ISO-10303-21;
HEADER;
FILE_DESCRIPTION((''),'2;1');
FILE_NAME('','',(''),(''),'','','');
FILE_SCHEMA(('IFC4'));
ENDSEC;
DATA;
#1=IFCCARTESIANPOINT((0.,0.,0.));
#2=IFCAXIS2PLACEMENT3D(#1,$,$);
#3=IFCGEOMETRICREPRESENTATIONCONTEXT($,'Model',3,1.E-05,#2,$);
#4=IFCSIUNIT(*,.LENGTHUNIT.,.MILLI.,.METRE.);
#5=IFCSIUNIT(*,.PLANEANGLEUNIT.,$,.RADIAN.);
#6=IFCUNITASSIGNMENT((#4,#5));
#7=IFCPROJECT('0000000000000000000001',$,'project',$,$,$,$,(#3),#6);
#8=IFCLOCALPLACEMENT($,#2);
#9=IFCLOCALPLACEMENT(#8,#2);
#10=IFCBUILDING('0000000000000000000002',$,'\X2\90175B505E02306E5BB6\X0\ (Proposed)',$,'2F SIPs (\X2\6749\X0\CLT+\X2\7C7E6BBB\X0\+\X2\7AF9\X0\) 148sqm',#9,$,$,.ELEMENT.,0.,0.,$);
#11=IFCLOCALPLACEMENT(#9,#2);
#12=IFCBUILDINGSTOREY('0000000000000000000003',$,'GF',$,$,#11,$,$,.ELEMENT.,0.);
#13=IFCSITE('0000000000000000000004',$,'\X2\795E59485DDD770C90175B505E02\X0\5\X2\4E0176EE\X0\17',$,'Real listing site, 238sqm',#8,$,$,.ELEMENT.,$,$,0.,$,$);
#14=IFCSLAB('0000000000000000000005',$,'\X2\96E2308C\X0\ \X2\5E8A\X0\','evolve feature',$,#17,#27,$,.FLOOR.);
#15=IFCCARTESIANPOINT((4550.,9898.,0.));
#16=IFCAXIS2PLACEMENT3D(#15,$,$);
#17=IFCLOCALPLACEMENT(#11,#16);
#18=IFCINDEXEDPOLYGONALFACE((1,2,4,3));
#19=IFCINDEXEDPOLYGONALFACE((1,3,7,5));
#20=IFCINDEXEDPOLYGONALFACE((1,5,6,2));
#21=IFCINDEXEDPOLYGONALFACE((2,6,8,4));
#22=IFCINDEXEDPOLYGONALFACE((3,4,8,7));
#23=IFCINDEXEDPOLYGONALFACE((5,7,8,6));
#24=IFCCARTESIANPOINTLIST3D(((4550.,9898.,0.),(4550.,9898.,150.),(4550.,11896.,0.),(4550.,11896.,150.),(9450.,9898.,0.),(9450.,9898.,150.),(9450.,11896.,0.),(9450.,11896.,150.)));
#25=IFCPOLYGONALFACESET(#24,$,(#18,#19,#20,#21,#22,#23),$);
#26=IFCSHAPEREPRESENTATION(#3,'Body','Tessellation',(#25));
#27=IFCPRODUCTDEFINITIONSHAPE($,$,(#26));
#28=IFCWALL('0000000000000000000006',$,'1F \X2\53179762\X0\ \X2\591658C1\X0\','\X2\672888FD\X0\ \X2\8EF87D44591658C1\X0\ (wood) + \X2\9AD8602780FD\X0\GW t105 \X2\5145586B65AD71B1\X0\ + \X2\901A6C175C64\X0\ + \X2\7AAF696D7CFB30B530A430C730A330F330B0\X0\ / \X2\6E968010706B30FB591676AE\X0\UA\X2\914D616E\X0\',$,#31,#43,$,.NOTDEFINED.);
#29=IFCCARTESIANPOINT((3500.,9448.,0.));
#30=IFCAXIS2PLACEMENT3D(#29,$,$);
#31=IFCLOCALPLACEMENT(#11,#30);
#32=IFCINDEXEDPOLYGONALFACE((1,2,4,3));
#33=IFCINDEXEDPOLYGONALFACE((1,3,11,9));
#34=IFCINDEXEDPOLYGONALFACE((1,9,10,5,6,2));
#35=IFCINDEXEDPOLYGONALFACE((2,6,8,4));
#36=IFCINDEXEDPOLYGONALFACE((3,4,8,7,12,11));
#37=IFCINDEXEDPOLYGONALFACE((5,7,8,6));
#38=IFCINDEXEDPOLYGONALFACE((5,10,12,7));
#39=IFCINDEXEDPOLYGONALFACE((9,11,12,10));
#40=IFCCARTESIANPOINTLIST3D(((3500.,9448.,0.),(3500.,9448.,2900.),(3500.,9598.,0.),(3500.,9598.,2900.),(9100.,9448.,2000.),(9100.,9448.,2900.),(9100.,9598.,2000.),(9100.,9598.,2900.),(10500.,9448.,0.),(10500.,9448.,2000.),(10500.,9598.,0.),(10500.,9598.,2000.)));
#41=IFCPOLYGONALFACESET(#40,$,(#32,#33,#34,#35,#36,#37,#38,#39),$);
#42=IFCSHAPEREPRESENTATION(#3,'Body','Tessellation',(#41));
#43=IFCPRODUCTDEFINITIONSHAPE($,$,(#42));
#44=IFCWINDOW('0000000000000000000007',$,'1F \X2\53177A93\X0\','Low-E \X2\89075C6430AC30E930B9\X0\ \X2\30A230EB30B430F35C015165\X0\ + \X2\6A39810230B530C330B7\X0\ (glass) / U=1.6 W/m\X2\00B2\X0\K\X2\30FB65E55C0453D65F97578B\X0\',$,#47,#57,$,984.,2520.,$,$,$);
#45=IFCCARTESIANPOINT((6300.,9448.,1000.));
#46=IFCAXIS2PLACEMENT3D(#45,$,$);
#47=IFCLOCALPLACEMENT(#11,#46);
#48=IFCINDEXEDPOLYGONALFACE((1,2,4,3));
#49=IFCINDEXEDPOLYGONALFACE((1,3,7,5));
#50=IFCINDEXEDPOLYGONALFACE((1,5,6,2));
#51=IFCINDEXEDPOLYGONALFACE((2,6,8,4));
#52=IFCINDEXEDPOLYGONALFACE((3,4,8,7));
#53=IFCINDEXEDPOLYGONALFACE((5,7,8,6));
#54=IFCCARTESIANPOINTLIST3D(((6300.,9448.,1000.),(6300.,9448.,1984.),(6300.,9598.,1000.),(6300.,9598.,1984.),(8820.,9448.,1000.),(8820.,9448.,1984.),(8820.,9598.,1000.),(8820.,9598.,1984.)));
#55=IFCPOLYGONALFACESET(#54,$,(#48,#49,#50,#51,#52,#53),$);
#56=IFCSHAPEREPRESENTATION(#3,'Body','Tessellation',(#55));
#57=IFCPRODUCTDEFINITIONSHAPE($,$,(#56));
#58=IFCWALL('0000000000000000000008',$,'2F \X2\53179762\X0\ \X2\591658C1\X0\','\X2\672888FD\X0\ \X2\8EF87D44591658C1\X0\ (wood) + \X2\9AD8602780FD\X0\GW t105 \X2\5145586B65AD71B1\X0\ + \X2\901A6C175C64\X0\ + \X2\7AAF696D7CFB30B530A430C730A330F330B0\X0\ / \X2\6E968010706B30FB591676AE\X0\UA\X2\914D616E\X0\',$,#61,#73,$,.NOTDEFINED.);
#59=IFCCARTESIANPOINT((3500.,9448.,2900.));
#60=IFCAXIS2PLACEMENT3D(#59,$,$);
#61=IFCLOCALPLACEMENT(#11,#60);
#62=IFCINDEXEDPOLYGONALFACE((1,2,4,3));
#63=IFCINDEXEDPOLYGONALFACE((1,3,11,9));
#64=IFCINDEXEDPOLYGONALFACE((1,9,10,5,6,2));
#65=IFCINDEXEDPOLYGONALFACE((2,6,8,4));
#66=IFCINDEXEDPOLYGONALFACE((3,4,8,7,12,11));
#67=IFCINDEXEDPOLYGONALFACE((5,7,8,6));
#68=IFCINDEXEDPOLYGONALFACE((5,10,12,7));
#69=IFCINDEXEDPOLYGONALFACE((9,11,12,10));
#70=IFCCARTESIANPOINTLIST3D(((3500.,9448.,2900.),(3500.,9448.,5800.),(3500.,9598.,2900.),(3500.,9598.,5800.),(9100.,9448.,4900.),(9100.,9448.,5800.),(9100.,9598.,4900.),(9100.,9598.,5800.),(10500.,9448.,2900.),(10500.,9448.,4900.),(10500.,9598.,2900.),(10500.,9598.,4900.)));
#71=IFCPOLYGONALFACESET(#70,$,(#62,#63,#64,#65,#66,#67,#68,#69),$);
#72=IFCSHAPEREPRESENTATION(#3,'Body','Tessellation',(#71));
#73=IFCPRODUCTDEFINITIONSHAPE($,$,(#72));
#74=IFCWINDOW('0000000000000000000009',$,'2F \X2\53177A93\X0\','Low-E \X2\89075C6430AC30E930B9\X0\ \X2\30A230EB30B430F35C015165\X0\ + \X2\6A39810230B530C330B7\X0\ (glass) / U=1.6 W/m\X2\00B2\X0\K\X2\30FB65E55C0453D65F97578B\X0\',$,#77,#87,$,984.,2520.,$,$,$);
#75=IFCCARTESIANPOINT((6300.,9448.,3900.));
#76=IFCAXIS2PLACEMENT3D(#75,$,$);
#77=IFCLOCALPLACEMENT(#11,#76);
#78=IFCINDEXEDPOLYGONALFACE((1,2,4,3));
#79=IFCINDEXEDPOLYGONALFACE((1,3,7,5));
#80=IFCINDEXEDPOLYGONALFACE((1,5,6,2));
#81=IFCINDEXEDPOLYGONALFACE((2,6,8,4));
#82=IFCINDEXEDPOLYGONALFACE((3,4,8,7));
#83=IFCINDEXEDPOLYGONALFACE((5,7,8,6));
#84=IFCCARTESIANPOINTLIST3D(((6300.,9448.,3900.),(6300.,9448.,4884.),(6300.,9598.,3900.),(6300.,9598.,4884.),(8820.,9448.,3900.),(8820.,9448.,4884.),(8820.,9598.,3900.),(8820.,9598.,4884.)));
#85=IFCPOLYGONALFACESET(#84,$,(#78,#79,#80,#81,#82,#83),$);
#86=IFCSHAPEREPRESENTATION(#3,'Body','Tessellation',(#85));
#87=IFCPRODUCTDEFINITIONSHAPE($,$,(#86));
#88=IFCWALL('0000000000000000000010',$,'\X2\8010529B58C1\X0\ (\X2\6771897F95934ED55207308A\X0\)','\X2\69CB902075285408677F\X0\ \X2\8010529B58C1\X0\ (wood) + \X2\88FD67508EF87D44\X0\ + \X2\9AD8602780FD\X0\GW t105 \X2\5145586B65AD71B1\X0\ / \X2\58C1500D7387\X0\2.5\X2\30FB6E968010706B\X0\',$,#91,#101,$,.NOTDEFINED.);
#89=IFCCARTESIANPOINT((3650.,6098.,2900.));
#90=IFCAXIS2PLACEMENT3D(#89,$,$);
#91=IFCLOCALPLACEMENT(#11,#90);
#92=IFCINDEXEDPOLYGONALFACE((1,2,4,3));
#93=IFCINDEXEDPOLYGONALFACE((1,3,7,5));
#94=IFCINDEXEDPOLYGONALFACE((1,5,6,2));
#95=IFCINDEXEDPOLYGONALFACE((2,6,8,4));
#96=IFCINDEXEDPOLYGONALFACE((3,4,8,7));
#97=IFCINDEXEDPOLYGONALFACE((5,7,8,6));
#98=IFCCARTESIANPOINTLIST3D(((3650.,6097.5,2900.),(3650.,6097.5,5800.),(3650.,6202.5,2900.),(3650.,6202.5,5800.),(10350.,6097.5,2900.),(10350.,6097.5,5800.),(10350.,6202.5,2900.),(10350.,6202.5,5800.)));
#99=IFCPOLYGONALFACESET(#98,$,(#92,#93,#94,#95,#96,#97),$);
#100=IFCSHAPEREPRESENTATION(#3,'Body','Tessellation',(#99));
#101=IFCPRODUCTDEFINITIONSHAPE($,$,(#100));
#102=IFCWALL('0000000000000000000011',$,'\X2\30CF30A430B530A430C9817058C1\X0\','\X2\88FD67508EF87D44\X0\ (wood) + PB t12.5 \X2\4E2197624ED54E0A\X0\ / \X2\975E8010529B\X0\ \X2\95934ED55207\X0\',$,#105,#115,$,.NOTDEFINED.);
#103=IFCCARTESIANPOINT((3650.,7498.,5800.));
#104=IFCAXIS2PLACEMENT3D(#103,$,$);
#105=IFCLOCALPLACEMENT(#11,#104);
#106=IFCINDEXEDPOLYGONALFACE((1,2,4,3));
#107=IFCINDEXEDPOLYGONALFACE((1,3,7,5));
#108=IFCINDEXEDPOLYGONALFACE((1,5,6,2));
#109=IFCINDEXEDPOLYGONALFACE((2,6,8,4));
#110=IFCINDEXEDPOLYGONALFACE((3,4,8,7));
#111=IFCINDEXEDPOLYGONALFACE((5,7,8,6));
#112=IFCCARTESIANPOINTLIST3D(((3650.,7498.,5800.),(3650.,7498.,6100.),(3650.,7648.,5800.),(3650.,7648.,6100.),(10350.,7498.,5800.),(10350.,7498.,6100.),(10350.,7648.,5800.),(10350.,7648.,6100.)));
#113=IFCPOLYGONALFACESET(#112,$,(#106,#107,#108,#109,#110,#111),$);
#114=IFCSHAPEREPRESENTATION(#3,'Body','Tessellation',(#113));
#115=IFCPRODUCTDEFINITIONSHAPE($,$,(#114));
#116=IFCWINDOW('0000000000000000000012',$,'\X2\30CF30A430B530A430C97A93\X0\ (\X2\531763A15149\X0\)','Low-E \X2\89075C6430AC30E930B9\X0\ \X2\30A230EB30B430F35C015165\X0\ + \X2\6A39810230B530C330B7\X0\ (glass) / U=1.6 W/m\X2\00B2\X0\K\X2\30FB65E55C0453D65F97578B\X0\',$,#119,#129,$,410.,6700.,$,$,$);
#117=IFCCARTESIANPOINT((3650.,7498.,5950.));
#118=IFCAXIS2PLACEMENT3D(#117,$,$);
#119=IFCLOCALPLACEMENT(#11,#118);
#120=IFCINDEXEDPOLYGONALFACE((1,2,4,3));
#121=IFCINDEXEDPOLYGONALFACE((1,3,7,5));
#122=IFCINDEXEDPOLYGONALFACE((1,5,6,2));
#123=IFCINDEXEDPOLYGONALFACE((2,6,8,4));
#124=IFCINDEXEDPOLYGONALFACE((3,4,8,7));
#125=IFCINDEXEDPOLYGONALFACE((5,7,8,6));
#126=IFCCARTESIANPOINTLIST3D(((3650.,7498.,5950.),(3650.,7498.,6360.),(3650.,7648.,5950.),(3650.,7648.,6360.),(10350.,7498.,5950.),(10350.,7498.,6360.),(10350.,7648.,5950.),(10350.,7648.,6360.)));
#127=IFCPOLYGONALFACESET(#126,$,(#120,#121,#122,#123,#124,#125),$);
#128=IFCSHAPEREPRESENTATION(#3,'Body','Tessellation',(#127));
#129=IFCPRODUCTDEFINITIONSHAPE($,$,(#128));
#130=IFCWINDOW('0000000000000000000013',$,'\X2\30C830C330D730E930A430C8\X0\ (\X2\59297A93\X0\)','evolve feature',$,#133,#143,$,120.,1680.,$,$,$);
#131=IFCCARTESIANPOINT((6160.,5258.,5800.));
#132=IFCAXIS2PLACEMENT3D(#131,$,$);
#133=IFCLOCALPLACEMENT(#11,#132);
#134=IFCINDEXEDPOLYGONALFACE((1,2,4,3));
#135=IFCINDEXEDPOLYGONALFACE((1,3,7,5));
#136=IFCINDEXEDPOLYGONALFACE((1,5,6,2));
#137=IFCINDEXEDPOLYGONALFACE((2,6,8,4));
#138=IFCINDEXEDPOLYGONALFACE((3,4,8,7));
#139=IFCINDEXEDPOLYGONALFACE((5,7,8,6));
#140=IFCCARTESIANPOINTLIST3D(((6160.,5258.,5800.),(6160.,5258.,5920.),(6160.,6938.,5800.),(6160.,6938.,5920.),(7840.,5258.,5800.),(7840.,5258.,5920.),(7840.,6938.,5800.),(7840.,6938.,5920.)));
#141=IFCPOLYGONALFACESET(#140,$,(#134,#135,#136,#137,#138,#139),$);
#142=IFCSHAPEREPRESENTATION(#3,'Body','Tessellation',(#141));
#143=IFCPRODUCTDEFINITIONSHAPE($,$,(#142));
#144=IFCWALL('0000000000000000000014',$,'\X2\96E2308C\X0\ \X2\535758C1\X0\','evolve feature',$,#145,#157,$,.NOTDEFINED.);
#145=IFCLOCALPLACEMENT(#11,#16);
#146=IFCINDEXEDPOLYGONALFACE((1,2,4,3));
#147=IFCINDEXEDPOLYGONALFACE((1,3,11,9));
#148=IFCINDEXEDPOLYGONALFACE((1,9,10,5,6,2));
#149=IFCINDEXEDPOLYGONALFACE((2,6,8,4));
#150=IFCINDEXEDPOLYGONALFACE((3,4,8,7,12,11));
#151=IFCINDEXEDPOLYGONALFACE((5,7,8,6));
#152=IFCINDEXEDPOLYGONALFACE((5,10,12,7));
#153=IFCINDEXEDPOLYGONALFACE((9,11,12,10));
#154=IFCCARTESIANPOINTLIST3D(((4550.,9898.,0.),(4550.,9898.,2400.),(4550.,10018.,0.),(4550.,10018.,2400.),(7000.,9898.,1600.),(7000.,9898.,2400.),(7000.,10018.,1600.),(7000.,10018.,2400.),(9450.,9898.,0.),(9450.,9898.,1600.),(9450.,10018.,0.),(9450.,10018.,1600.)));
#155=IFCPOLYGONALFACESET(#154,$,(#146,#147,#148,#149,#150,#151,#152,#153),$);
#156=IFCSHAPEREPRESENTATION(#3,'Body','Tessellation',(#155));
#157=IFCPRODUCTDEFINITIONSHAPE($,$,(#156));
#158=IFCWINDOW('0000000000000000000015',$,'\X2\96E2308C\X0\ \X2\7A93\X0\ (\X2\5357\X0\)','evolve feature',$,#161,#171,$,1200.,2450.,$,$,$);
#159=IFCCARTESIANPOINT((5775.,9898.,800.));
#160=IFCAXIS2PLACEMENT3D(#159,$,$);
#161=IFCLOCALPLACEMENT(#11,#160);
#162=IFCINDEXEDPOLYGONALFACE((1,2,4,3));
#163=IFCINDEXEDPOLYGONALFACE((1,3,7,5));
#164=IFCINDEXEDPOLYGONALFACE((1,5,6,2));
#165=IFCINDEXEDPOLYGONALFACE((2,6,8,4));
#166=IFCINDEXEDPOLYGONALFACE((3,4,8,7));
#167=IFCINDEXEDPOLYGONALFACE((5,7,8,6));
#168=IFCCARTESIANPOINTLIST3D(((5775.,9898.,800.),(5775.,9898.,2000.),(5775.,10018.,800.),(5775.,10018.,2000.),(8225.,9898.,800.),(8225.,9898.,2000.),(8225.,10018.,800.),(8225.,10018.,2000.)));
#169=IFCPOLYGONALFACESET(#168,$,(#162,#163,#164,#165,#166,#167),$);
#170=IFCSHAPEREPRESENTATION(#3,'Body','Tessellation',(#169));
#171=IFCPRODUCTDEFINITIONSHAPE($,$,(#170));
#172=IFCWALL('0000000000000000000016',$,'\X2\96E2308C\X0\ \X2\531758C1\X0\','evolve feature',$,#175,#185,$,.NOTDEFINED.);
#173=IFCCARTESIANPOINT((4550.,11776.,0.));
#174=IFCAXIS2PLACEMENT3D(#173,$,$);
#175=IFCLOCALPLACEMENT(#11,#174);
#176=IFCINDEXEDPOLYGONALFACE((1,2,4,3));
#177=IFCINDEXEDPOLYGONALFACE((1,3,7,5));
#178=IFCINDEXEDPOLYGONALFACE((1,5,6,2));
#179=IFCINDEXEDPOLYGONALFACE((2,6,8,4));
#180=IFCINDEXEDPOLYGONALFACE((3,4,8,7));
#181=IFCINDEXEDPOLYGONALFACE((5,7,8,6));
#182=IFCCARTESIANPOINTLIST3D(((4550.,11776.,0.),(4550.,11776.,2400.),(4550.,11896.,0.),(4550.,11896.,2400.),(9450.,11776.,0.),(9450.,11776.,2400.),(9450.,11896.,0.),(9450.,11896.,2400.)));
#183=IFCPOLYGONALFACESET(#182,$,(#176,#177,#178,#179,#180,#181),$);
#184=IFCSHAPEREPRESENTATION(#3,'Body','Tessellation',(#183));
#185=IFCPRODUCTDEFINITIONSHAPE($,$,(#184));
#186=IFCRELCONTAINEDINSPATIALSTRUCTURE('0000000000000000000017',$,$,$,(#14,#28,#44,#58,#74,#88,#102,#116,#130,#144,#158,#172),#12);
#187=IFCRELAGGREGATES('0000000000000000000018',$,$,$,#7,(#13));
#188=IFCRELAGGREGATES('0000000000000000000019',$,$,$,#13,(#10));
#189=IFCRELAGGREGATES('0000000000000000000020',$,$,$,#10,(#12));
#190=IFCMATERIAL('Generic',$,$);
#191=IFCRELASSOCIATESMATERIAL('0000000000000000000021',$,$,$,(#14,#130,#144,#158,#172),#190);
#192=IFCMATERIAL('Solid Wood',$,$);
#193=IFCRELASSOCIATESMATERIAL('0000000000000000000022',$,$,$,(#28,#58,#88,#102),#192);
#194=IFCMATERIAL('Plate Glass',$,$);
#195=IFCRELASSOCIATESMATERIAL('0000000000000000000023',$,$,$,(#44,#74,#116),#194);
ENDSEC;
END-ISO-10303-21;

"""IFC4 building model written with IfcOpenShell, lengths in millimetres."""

from ifc_helpers import new_model, si_unit, frame, frame_2d, origin, place, context, project, spatial, rectangle, extrude, material, element, fill, save


model = new_model("IFC4")

# Units and contexts
model_context = context("Model", 3, precision=1e-05, world=origin())
ifc_project = project(units=[si_unit("LENGTHUNIT", "METRE", prefix="MILLI"), si_unit("PLANEANGLEUNIT", "RADIAN")], contexts=[model_context])

# Site, building, storey
site_placement = place(None, origin())
site = spatial("IfcSite", under=ifc_project, at=site_placement, Name="神奈川県逗子市5丁目17", ObjectType="Real listing site, 238sqm", CompositionType="ELEMENT", RefElevation=0.0)
building_placement = place(site_placement, origin())
building = spatial("IfcBuilding", under=site, at=building_placement, Name="逗子市の家 (Proposed)", ObjectType="2F SIPs (杉CLT+籾殻+竹) 148sqm", CompositionType="ELEMENT", ElevationOfRefHeight=0.0, ElevationOfTerrain=0.0)
storey_placement = place(building_placement, origin())
storey = spatial("IfcBuildingStorey", under=building, at=storey_placement, Name="GF", CompositionType="ELEMENT", Elevation=0.0)

# Slab
ifc_material_1 = material(Name="Generic")
slab_placement = place(storey_placement, frame((4550.0, 9898.0, 0.0)))
element("IfcSlab", 1, at=slab_placement, inside=storey, material=ifc_material_1, Name="離れ 床", Description="evolve feature", PredefinedType="FLOOR", context=model_context, shape_type="SweptSolid", body=[
    extrude(rectangle(XDim=4900.0, YDim=1998.0, at=frame_2d((2450.0, 999.0))), frame((4550.0, 9898.0, 0.0)), (0.0, 0.0, 1.0), 150.0),
])

# Wall, opening, window
ifc_material_2 = material(Name="Solid Wood")
wall_1_placement = place(storey_placement, frame((3500.0, 9448.0, 0.0)))
wall_1 = element("IfcWall", 2, at=wall_1_placement, inside=storey, material=ifc_material_2, Name="1F 北面 外壁", Description="木製 軸組外壁 (wood) + 高性能GW t105 充填断熱 + 通気層 + 窯業系サイディング / 準耐火・外皮UA配慮", PredefinedType="NOTDEFINED", context=model_context, shape_type="SweptSolid", body=[
    extrude(rectangle(XDim=7000.0, YDim=150.0, at=frame_2d((3500.0, 75.0))), frame((3500.0, 9448.0, 0.0)), (0.0, 0.0, 1.0), 2900.0),
])
opening_1_placement = place(storey_placement, frame((6300.0, 9448.0, 1000.0)))
opening_1 = element("IfcOpeningElement", 3, at=opening_1_placement, cuts=wall_1, PredefinedType="NOTDEFINED", context=model_context, shape_type="SweptSolid", body=[
    extrude(rectangle(XDim=2520.0, YDim=150.0, at=frame_2d((1260.0, 75.0))), frame((6300.0, 9448.0, 1000.0)), (0.0, 0.0, 1.0), 984.0),
])
ifc_material_3 = material(Name="Plate Glass")
window_1_placement = place(storey_placement, frame((6300.0, 9448.0, 1000.0)))
window_1 = element("IfcWindow", 4, at=window_1_placement, inside=storey, material=ifc_material_3, Name="1F 北窓", Description="Low-E 複層ガラス アルゴン封入 + 樹脂サッシ (glass) / U=1.6 W/m²K・日射取得型", OverallHeight=984.0, OverallWidth=2520.0, context=model_context, shape_type="SweptSolid", body=[
    extrude(rectangle(XDim=2520.0, YDim=150.0, at=frame_2d((1260.0, 75.0))), frame((6300.0, 9448.0, 1000.0)), (0.0, 0.0, 1.0), 984.0),
])
fill(opening_1, window_1)

# Wall, opening, window
wall_2_placement = place(storey_placement, frame((3500.0, 9448.0, 2900.0)))
wall_2 = element("IfcWall", 5, at=wall_2_placement, inside=storey, material=ifc_material_2, Name="2F 北面 外壁", Description="木製 軸組外壁 (wood) + 高性能GW t105 充填断熱 + 通気層 + 窯業系サイディング / 準耐火・外皮UA配慮", PredefinedType="NOTDEFINED", context=model_context, shape_type="SweptSolid", body=[
    extrude(rectangle(XDim=7000.0, YDim=150.0, at=frame_2d((3500.0, 75.0))), frame((3500.0, 9448.0, 2900.0)), (0.0, 0.0, 1.0), 2900.0),
])
opening_2_placement = place(storey_placement, frame((6300.0, 9448.0, 3900.0)))
opening_2 = element("IfcOpeningElement", 6, at=opening_2_placement, cuts=wall_2, PredefinedType="NOTDEFINED", context=model_context, shape_type="SweptSolid", body=[
    extrude(rectangle(XDim=2520.0, YDim=150.0, at=frame_2d((1260.0, 75.0))), frame((6300.0, 9448.0, 3900.0)), (0.0, 0.0, 1.0), 984.0),
])
window_2_placement = place(storey_placement, frame((6300.0, 9448.0, 3900.0)))
window_2 = element("IfcWindow", 7, at=window_2_placement, inside=storey, material=ifc_material_3, Name="2F 北窓", Description="Low-E 複層ガラス アルゴン封入 + 樹脂サッシ (glass) / U=1.6 W/m²K・日射取得型", OverallHeight=984.0, OverallWidth=2520.0, context=model_context, shape_type="SweptSolid", body=[
    extrude(rectangle(XDim=2520.0, YDim=150.0, at=frame_2d((1260.0, 75.0))), frame((6300.0, 9448.0, 3900.0)), (0.0, 0.0, 1.0), 984.0),
])
fill(opening_2, window_2)

# Wall
wall_3_placement = place(storey_placement, frame((3650.0, 6098.0, 2900.0)))
element("IfcWall", 8, at=wall_3_placement, inside=storey, material=ifc_material_2, Name="耐力壁 (東西間仕切り)", Description="構造用合板 耐力壁 (wood) + 製材軸組 + 高性能GW t105 充填断熱 / 壁倍率2.5・準耐火", PredefinedType="NOTDEFINED", context=model_context, shape_type="SweptSolid", body=[
    extrude(rectangle(XDim=6700.0, YDim=105.0, at=frame_2d((3350.0, 52.0))), frame((3650.0, 6098.0, 2900.0)), (0.0, 0.0, 1.0), 2900.0),
])

# Wall, opening, window
wall_4_placement = place(storey_placement, frame((3650.0, 7498.0, 5800.0)))
wall_4 = element("IfcWall", 9, at=wall_4_placement, inside=storey, material=ifc_material_2, Name="ハイサイド腰壁", Description="製材軸組 (wood) + PB t12.5 両面仕上 / 非耐力 間仕切", PredefinedType="NOTDEFINED", context=model_context, shape_type="SweptSolid", body=[
    extrude(rectangle(XDim=6700.0, YDim=150.0, at=frame_2d((3350.0, 75.0))), frame((3650.0, 7498.0, 5800.0)), (0.0, 0.0, 1.0), 700.0),
])
opening_3_placement = place(storey_placement, frame((3650.0, 7498.0, 5950.0)))
opening_3 = element("IfcOpeningElement", 10, at=opening_3_placement, cuts=wall_4, PredefinedType="NOTDEFINED", context=model_context, shape_type="SweptSolid", body=[
    extrude(rectangle(XDim=6700.0, YDim=150.0, at=frame_2d((3350.0, 75.0))), frame((3650.0, 7498.0, 5950.0)), (0.0, 0.0, 1.0), 410.0),
])
window_3_placement = place(storey_placement, frame((3650.0, 7498.0, 5950.0)))
window_3 = element("IfcWindow", 11, at=window_3_placement, inside=storey, material=ifc_material_3, Name="ハイサイド窓 (北採光)", Description="Low-E 複層ガラス アルゴン封入 + 樹脂サッシ (glass) / U=1.6 W/m²K・日射取得型", OverallHeight=410.0, OverallWidth=6700.0, context=model_context, shape_type="SweptSolid", body=[
    extrude(rectangle(XDim=6700.0, YDim=150.0, at=frame_2d((3350.0, 75.0))), frame((3650.0, 7498.0, 5950.0)), (0.0, 0.0, 1.0), 410.0),
])
fill(opening_3, window_3)

# Window
window_4_placement = place(storey_placement, frame((6160.0, 5258.0, 5800.0)))
element("IfcWindow", 12, at=window_4_placement, inside=storey, material=ifc_material_1, Name="トップライト (天窓)", Description="evolve feature", OverallHeight=120.0, OverallWidth=1680.0, context=model_context, shape_type="SweptSolid", body=[
    extrude(rectangle(XDim=1680.0, YDim=1680.0, at=frame_2d((840.0, 840.0))), frame((6160.0, 5258.0, 5800.0)), (0.0, 0.0, 1.0), 120.0),
])

# Wall, opening, window
wall_5_placement = place(storey_placement, frame((4550.0, 9898.0, 0.0)))
wall_5 = element("IfcWall", 13, at=wall_5_placement, inside=storey, material=ifc_material_1, Name="離れ 南壁", Description="evolve feature", PredefinedType="NOTDEFINED", context=model_context, shape_type="SweptSolid", body=[
    extrude(rectangle(XDim=4900.0, YDim=120.0, at=frame_2d((2450.0, 60.0))), frame((4550.0, 9898.0, 0.0)), (0.0, 0.0, 1.0), 2400.0),
])
opening_4_placement = place(storey_placement, frame((5775.0, 9898.0, 800.0)))
opening_4 = element("IfcOpeningElement", 14, at=opening_4_placement, cuts=wall_5, PredefinedType="NOTDEFINED", context=model_context, shape_type="SweptSolid", body=[
    extrude(rectangle(XDim=2450.0, YDim=120.0, at=frame_2d((1225.0, 60.0))), frame((5775.0, 9898.0, 800.0)), (0.0, 0.0, 1.0), 1200.0),
])
window_5_placement = place(storey_placement, frame((5775.0, 9898.0, 800.0)))
window_5 = element("IfcWindow", 15, at=window_5_placement, inside=storey, material=ifc_material_1, Name="離れ 窓 (南)", Description="evolve feature", OverallHeight=1200.0, OverallWidth=2450.0, context=model_context, shape_type="SweptSolid", body=[
    extrude(rectangle(XDim=2450.0, YDim=120.0, at=frame_2d((1225.0, 60.0))), frame((5775.0, 9898.0, 800.0)), (0.0, 0.0, 1.0), 1200.0),
])
fill(opening_4, window_5)

# Wall
wall_6_placement = place(storey_placement, frame((4550.0, 11776.0, 0.0)))
element("IfcWall", 16, at=wall_6_placement, inside=storey, material=ifc_material_1, Name="離れ 北壁", Description="evolve feature", PredefinedType="NOTDEFINED", context=model_context, shape_type="SweptSolid", body=[
    extrude(rectangle(XDim=4900.0, YDim=120.0, at=frame_2d((2450.0, 60.0))), frame((4550.0, 11776.0, 0.0)), (0.0, 0.0, 1.0), 2400.0),
])

save(model, "model.ifc")
